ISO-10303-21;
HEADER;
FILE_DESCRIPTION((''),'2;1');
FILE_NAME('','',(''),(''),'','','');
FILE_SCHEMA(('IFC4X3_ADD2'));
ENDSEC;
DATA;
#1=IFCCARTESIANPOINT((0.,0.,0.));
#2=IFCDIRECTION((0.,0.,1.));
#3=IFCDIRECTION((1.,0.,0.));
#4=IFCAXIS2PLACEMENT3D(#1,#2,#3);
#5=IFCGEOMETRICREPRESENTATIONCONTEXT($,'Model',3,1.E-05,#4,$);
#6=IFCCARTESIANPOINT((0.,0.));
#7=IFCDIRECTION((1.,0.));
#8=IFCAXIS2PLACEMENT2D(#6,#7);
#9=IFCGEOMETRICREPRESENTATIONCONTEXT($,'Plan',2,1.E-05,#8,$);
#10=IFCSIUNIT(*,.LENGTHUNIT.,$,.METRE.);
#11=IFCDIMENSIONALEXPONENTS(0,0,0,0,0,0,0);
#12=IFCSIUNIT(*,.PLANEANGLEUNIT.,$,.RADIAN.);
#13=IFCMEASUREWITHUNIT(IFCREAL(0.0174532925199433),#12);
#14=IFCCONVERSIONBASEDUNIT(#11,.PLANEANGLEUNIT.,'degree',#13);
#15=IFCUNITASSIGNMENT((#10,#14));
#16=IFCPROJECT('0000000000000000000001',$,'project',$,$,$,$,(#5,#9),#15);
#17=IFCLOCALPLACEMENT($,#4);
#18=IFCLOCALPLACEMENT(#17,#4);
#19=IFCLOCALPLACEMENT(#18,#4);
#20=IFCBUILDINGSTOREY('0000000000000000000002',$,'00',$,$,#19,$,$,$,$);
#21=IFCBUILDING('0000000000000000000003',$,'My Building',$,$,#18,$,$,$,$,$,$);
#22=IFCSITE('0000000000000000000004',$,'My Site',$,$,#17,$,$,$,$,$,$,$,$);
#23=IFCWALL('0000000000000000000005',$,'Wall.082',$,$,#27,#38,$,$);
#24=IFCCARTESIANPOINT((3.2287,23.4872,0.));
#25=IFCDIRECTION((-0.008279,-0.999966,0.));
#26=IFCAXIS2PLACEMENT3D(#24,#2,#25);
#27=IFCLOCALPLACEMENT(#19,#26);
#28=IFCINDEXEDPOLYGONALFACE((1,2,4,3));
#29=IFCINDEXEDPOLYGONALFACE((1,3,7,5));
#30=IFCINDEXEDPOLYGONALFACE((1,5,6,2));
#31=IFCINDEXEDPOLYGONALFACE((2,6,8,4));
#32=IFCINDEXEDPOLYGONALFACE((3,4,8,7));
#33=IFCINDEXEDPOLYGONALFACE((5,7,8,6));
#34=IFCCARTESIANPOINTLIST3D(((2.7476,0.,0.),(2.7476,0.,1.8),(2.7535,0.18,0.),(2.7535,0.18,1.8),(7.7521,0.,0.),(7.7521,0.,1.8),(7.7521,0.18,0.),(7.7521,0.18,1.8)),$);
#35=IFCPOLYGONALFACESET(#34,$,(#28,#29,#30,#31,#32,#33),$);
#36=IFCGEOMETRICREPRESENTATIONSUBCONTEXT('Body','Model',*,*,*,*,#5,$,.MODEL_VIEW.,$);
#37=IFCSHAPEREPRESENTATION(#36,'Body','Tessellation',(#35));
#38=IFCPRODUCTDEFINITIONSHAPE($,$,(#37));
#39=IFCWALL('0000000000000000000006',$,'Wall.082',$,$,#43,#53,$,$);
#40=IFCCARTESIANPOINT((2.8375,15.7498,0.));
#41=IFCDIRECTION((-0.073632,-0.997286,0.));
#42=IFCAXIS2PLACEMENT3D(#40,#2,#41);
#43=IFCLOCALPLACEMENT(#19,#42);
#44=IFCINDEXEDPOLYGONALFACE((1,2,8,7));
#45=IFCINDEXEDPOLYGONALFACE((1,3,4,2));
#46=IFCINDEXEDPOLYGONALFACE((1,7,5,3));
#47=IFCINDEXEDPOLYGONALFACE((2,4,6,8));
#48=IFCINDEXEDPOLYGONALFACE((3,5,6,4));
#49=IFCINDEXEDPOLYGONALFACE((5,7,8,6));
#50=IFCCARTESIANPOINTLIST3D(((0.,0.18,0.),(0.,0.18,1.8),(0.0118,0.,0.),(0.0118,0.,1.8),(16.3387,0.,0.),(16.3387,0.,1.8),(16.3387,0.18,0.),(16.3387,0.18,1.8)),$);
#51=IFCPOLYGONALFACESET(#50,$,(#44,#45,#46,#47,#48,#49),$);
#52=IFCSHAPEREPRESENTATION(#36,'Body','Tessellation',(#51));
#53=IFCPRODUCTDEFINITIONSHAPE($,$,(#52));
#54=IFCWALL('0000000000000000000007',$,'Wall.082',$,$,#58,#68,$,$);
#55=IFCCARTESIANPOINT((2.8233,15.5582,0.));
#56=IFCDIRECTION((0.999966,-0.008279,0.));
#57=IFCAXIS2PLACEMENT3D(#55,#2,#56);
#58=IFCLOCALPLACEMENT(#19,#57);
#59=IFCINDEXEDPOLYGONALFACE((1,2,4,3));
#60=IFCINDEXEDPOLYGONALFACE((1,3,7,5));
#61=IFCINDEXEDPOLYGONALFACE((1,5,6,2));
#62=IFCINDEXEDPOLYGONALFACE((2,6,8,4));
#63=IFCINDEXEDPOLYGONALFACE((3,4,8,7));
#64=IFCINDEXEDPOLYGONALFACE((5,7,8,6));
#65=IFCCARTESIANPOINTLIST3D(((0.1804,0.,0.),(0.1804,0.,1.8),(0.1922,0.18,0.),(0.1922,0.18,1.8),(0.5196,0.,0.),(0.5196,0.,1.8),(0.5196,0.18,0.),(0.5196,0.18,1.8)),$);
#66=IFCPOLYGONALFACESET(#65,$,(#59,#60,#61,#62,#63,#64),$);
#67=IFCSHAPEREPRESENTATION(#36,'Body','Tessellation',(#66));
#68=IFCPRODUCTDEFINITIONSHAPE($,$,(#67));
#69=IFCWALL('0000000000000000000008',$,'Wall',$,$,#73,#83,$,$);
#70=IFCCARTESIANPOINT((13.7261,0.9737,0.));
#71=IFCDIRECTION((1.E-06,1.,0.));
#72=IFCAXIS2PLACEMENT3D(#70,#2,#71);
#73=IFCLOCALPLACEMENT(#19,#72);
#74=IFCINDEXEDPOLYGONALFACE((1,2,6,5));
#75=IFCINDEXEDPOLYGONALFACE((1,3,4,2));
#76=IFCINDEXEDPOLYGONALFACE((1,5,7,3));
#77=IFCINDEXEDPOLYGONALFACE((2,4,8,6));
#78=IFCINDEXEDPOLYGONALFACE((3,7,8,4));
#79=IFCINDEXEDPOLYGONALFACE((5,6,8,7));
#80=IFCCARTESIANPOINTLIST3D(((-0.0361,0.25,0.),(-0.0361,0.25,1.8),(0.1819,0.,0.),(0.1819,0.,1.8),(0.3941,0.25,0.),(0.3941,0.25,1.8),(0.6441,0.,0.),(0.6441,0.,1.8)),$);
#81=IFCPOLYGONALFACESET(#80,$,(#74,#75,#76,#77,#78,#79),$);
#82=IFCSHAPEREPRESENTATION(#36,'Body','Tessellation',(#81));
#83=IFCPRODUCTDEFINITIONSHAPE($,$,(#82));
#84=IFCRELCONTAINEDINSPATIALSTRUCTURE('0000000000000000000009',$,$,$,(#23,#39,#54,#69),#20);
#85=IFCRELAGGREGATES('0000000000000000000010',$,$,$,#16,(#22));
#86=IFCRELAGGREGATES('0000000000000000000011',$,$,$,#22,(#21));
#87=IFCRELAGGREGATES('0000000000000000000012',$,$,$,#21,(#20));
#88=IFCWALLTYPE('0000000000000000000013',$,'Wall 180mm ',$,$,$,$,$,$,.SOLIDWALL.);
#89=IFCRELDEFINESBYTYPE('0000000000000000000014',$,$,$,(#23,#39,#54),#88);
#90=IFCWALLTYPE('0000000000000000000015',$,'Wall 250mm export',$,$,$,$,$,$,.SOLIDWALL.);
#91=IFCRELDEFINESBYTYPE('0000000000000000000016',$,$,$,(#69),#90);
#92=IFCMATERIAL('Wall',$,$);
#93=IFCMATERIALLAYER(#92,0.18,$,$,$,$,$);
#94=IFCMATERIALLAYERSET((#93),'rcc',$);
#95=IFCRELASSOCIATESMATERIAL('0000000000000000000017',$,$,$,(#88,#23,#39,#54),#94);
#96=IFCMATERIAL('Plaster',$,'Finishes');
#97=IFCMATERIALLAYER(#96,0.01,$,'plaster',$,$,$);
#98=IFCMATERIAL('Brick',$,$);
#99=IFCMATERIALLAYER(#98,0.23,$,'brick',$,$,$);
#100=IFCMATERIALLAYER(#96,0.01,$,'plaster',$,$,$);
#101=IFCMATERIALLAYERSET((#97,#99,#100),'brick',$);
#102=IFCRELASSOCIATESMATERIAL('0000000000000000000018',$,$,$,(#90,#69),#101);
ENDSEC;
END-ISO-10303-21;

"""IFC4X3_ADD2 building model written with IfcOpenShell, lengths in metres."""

from ifc_helpers import new_model, entity, si_unit, converted_unit, frame, origin_with_axes, origin_2d_with_axis, place, context, subcontext, project, spatial, line, indexed_curve, outline, extrude, clip, halfspace, material, layer, layer_set, layer_usage, type_object, element, save


model = new_model("IFC4X3_ADD2")

# Units and contexts
model_context = context("Model", 3, precision=1e-05, world=origin_with_axes())
plan_context = context("Plan", 2, precision=1e-05, world=origin_2d_with_axis())
body_context_1 = subcontext(model_context, "Body", "Model", "MODEL_VIEW")
ifc_project = project(units=[si_unit("LENGTHUNIT", "METRE"), converted_unit("PLANEANGLEUNIT", "degree", entity("IfcReal", 0.0174532925199433), si_unit("PLANEANGLEUNIT", "RADIAN"), dimensions=[0, 0, 0, 0, 0, 0, 0])], contexts=[model_context, plan_context])

# Site, building, storey
site_placement = place(None, origin_with_axes())
site = spatial("IfcSite", under=ifc_project, at=site_placement, Name="My Site")
building_placement = place(site_placement, origin_with_axes())
building = spatial("IfcBuilding", under=site, at=building_placement, Name="My Building")
storey_placement = place(building_placement, origin_with_axes())
storey = spatial("IfcBuildingStorey", under=building, at=storey_placement, Name="00")

# Shared definitions
ifc_material_1 = material(Name="Wall")
ifc_layer_1 = layer(ifc_material_1, 0.18)
ifc_layer_set_1 = layer_set([ifc_layer_1], Name="rcc")
wall_type_1 = type_object("IfcWallType", Name="Wall 180mm ", PredefinedType="SOLIDWALL", material=ifc_layer_set_1)

# Walls
ifc_layer_usage_1 = layer_usage(ifc_layer_set_1, "AXIS2", "POSITIVE", 0.0)
wall_1_placement = place(storey_placement, frame((3.2287, 23.4872, 0.0), z_axis=(0.0, 0.0, 1.0), x_axis=(-0.008279, -0.999966, 0.0)))
element("IfcWall", 1, at=wall_1_placement, inside=storey, type_object=wall_type_1, material=ifc_layer_usage_1, Name="Wall.082", context=body_context_1, shape_type="Clipping", body=[
    clip(extrude(outline(indexed_curve([(0.0, 0.0), (0.0, 0.18), (7.7521, 0.18), (7.7521, 0.0), (0.0, 0.0)], self_intersect=False)), origin_with_axes(), (0.0, 0.0, 1.0), 1.8), halfspace(frame((2.7476, 0.0, 0.0), z_axis=(-0.999463, 0.032755, 0.0), x_axis=(0.032755, 0.999463, 0.0)), False)),
])
ifc_layer_usage_2 = layer_usage(ifc_layer_set_1, "AXIS2", "POSITIVE", 0.0)
wall_2_placement = place(storey_placement, frame((2.8375, 15.7498, 0.0), z_axis=(0.0, 0.0, 1.0), x_axis=(-0.073632, -0.997286, 0.0)))
element("IfcWall", 2, at=wall_2_placement, inside=storey, type_object=wall_type_1, material=ifc_layer_usage_2, Name="Wall.082", context=body_context_1, shape_type="Clipping", body=[
    clip(extrude(outline(indexed_curve([(0.0, 0.0), (0.0, 0.18), (16.3387, 0.18), (16.3387, 0.0), (0.0, 0.0)], self_intersect=False)), origin_with_axes(), (0.0, 0.0, 1.0), 1.8), halfspace(frame((0.0118, 0.0, 0.0), z_axis=(-0.324, -0.021226, 0.0), x_axis=(-0.065372, 0.997861, 0.0)), False)),
])
ifc_layer_usage_3 = layer_usage(ifc_layer_set_1, "AXIS2", "POSITIVE", 0.0)
wall_3_placement = place(storey_placement, frame((2.8233, 15.5582, 0.0), z_axis=(0.0, 0.0, 1.0), x_axis=(0.999966, -0.008279, 0.0)))
element("IfcWall", 3, at=wall_3_placement, inside=storey, type_object=wall_type_1, material=ifc_layer_usage_3, Name="Wall.082", context=body_context_1, shape_type="Clipping", body=[
    clip(extrude(outline(indexed_curve([(0.0, 0.0), (0.0, 0.18), (0.5196, 0.18), (0.5196, 0.0), (0.0, 0.0)], self_intersect=False)), origin_with_axes(), (0.0, 0.0, 1.0), 1.8), halfspace(frame((0.1804, 0.0, 0.0), z_axis=(-0.323997, 0.021226, 0.0), x_axis=(0.065371, 0.997861, 0.0)), False)),
])
ifc_material_2 = material(Name="Plaster", Category="Finishes")
ifc_layer_2 = layer(ifc_material_2, 0.01, Name="plaster")
ifc_material_3 = material(Name="Brick")
ifc_layer_3 = layer(ifc_material_3, 0.23, Name="brick")
ifc_layer_4 = layer(ifc_material_2, 0.01, Name="plaster")
ifc_layer_set_2 = layer_set([ifc_layer_2, ifc_layer_3, ifc_layer_4], Name="brick")
wall_type_2 = type_object("IfcWallType", Name="Wall 250mm export", PredefinedType="SOLIDWALL", material=ifc_layer_set_2)

# Wall
ifc_layer_usage_4 = layer_usage(ifc_layer_set_2, "AXIS2", "POSITIVE", 0.0)
wall_4_placement = place(storey_placement, frame((13.7261, 0.9737, 0.0), z_axis=(0.0, 0.0, 1.0), x_axis=(0.000001, 1.0, 0.0)))
element("IfcWall", 4, at=wall_4_placement, inside=storey, type_object=wall_type_2, material=ifc_layer_usage_4, Name="Wall", context=body_context_1, shape_type="SweptSolid", body=[
    extrude(outline(indexed_curve([(0.1819, 0.0), (-0.0361, 0.25), (0.3941, 0.25), (0.6441, 0.0)], segments=[line(1, 2, 3, 4, 1)])), origin_with_axes(), (0.0, 0.0, 1.0), 1.8),
])

save(model, "model.ifc")
